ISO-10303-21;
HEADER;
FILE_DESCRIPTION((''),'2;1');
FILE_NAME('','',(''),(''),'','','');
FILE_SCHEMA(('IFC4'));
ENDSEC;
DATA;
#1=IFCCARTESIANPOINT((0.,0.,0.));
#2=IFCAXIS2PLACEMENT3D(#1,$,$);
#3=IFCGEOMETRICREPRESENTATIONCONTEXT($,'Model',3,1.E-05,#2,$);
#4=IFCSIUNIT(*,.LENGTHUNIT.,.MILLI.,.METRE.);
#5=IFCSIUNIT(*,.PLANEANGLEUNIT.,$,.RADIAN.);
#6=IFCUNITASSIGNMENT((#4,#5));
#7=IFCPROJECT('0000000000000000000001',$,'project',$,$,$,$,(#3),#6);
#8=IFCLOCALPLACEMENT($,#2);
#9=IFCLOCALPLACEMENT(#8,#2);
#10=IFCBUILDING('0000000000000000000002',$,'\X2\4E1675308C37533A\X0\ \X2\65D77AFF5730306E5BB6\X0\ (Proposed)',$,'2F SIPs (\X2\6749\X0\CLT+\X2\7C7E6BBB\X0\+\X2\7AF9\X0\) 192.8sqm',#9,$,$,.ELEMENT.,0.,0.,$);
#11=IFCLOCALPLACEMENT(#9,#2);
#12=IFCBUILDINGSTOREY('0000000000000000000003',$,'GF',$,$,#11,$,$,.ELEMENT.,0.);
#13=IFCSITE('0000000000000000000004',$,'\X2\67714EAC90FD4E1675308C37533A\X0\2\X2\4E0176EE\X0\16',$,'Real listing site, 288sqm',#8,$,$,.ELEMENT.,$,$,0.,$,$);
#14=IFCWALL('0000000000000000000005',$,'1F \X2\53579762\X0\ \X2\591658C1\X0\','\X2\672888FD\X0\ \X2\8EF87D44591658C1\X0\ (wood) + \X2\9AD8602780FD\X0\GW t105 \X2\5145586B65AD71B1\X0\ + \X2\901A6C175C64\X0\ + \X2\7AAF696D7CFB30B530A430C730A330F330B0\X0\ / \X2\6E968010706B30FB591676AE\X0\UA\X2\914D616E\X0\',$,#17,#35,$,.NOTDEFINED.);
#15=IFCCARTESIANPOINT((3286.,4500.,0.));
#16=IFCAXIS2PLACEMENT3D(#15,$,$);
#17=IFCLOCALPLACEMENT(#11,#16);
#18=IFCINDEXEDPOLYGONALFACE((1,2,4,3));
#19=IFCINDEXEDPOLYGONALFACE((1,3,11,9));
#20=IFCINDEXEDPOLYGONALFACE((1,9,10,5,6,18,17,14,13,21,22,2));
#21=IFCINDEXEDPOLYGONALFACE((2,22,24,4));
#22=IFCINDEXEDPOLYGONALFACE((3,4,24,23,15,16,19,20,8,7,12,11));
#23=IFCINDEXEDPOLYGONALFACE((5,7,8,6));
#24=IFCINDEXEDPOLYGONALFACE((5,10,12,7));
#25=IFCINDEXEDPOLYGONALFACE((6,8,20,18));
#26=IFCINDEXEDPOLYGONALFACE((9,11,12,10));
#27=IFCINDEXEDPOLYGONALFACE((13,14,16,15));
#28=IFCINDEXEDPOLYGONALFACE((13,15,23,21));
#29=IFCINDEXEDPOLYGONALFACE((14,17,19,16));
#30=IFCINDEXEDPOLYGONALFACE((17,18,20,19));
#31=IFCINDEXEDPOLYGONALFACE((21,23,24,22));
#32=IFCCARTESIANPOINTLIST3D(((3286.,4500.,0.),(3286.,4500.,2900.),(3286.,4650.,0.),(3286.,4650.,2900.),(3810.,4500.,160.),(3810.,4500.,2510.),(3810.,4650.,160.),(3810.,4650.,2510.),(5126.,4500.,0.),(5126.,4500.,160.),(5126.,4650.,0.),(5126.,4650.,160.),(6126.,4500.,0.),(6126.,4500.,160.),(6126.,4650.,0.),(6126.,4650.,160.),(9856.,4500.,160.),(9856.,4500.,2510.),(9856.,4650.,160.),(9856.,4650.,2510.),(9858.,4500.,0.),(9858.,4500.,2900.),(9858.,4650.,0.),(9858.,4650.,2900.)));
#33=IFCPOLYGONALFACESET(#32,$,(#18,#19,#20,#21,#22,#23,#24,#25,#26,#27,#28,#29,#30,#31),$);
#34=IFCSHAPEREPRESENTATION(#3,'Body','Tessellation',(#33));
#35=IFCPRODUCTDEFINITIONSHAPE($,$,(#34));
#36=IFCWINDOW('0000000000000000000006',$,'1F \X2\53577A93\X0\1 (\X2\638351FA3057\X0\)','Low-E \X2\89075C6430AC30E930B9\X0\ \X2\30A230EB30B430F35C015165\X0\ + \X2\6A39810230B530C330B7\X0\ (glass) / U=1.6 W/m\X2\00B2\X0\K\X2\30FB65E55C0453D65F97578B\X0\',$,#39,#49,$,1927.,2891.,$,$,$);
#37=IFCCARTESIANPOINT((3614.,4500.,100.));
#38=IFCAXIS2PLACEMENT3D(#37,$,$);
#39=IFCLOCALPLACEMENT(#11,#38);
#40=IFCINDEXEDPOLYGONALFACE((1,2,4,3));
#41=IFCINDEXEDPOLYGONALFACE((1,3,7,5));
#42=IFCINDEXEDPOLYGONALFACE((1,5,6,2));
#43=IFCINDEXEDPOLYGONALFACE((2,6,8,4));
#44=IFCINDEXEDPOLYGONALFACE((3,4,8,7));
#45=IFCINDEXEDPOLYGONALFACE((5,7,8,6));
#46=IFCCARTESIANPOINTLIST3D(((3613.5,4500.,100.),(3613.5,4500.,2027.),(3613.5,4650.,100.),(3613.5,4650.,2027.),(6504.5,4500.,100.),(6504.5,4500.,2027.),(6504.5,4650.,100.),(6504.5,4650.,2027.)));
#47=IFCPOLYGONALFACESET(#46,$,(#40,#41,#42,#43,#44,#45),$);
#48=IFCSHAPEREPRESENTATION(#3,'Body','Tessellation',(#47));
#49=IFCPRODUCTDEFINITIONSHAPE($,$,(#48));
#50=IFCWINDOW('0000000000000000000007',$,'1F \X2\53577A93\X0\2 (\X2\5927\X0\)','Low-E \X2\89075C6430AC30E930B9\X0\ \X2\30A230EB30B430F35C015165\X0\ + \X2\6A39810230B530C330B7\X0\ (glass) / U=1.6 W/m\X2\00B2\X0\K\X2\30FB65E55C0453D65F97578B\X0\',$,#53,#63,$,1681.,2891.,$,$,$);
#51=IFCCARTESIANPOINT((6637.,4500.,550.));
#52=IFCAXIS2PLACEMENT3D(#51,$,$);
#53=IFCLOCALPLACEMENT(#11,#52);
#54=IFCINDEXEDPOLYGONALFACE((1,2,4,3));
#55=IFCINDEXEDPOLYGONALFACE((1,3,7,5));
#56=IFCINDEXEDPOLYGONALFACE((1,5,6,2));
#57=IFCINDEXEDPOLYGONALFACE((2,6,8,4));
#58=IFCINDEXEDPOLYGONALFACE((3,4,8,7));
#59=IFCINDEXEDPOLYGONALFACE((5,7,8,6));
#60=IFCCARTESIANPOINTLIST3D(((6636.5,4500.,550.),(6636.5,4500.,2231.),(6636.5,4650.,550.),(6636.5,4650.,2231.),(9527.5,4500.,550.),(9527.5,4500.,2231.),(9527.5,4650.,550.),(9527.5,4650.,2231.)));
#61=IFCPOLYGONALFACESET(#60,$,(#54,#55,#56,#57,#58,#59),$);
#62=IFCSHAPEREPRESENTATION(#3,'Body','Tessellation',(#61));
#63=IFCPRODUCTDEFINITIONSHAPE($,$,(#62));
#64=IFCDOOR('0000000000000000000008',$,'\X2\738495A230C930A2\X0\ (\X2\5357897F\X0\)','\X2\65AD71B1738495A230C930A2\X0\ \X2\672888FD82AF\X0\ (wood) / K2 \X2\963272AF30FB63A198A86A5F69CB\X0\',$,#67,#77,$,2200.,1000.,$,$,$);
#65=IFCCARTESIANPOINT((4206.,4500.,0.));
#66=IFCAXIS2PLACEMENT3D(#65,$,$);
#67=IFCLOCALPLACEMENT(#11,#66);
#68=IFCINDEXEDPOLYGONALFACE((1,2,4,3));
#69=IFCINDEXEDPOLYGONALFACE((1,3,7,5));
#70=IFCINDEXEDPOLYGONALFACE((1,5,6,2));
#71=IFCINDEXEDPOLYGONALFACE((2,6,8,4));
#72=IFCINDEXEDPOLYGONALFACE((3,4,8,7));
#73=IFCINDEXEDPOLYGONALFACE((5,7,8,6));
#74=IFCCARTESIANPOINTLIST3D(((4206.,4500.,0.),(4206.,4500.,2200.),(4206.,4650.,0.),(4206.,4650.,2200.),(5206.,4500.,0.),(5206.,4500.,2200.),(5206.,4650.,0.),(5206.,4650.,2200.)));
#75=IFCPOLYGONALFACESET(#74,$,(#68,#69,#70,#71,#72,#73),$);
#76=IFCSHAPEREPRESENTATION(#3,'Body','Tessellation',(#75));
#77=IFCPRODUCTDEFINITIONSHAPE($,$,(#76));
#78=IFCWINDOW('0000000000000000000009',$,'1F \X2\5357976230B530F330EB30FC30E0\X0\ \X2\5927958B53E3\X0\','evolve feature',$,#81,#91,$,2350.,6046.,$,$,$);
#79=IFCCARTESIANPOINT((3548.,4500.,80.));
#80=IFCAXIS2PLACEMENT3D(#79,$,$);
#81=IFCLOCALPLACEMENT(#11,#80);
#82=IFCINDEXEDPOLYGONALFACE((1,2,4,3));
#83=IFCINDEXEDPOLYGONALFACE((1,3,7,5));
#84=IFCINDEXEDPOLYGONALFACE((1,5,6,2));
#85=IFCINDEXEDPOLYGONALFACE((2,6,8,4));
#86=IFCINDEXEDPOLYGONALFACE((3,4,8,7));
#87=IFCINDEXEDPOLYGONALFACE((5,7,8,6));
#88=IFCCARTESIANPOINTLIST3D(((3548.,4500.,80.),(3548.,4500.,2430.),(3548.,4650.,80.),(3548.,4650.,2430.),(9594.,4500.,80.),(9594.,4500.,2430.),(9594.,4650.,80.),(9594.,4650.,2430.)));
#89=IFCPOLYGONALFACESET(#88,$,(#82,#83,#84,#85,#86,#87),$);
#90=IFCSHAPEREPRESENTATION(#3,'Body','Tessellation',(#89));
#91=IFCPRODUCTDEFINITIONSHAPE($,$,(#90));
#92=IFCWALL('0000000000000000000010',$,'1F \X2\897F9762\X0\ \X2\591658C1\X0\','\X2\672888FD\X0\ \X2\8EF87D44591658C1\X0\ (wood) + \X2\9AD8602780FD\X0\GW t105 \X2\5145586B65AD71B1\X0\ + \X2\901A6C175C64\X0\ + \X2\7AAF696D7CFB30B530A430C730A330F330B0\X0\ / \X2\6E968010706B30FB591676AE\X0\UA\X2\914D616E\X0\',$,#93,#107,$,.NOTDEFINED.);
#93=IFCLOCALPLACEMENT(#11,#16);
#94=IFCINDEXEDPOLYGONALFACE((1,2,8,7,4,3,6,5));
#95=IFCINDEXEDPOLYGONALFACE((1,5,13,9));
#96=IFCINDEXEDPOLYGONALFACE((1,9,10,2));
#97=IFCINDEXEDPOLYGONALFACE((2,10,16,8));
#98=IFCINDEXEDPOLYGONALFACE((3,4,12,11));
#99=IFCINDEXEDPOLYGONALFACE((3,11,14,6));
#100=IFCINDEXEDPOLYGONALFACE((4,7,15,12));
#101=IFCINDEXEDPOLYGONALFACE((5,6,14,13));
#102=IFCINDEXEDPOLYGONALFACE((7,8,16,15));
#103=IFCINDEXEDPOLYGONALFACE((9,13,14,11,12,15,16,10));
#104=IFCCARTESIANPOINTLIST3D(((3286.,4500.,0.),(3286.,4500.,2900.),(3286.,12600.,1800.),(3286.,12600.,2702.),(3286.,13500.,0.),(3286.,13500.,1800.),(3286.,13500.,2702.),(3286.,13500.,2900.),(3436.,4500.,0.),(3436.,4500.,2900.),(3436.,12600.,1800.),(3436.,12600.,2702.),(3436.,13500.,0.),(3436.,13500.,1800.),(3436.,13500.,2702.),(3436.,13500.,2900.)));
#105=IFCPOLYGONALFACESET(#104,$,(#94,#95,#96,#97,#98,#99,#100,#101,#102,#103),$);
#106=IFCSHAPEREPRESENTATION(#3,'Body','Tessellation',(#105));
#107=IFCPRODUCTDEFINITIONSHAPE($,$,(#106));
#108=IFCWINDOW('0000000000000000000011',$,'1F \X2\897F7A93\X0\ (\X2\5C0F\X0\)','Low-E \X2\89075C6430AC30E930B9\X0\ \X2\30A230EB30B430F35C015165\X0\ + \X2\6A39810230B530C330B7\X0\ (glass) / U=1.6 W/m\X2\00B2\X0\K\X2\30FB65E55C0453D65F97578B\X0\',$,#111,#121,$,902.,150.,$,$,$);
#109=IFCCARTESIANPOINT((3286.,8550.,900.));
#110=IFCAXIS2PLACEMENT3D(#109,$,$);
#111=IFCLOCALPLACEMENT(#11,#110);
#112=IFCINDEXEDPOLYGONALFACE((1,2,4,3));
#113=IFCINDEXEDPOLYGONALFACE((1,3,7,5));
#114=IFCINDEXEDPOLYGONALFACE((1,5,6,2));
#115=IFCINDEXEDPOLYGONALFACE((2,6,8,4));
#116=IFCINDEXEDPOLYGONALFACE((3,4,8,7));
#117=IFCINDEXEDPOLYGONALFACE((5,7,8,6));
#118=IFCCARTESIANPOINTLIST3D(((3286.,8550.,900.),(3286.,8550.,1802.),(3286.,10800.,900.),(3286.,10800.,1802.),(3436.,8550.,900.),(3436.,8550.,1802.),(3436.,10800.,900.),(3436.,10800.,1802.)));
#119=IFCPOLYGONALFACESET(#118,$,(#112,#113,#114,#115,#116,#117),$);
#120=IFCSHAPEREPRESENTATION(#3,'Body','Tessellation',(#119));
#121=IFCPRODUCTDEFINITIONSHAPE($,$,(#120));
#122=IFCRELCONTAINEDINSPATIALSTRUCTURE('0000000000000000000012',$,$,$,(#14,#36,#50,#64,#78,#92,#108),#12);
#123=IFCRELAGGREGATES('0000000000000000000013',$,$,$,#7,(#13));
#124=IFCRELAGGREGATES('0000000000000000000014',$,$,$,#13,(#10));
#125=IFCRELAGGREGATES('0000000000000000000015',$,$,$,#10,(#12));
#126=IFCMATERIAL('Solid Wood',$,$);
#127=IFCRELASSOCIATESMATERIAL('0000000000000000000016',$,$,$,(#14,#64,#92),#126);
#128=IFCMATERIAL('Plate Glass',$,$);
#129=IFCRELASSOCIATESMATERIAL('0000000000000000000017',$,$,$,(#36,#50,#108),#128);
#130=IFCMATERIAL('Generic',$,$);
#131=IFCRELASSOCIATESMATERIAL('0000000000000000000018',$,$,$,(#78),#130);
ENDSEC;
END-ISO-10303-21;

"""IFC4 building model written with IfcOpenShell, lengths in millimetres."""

from ifc_helpers import new_model, si_unit, frame, frame_2d, origin, place, context, project, spatial, rectangle, extrude, material, element, fill, save


model = new_model("IFC4")

# Units and contexts
model_context = context("Model", 3, precision=1e-05, world=origin())
ifc_project = project(units=[si_unit("LENGTHUNIT", "METRE", prefix="MILLI"), si_unit("PLANEANGLEUNIT", "RADIAN")], contexts=[model_context])

# Site, building, storey
site_placement = place(None, origin())
site = spatial("IfcSite", under=ifc_project, at=site_placement, Name="東京都世田谷区2丁目16", ObjectType="Real listing site, 288sqm", CompositionType="ELEMENT", RefElevation=0.0)
building_placement = place(site_placement, origin())
building = spatial("IfcBuilding", under=site, at=building_placement, Name="世田谷区 旗竿地の家 (Proposed)", ObjectType="2F SIPs (杉CLT+籾殻+竹) 192.8sqm", CompositionType="ELEMENT", ElevationOfRefHeight=0.0, ElevationOfTerrain=0.0)
storey_placement = place(building_placement, origin())
storey = spatial("IfcBuildingStorey", under=building, at=storey_placement, Name="GF", CompositionType="ELEMENT", Elevation=0.0)

# Shared definitions
ifc_material_1 = material(Name="Solid Wood")

# Wall, openings, windows, door
wall_1_placement = place(storey_placement, frame((3286.0, 4500.0, 0.0)))
wall_1 = element("IfcWall", 1, at=wall_1_placement, inside=storey, material=ifc_material_1, Name="1F 南面 外壁", Description="木製 軸組外壁 (wood) + 高性能GW t105 充填断熱 + 通気層 + 窯業系サイディング / 準耐火・外皮UA配慮", PredefinedType="NOTDEFINED", context=model_context, shape_type="SweptSolid", body=[
    extrude(rectangle(XDim=6572.0, YDim=150.0, at=frame_2d((3286.0, 75.0))), frame((3286.0, 4500.0, 0.0)), (0.0, 0.0, 1.0), 2900.0),
])
opening_1_placement = place(storey_placement, frame((3614.0, 4500.0, 100.0)))
opening_1 = element("IfcOpeningElement", 2, at=opening_1_placement, cuts=wall_1, PredefinedType="NOTDEFINED", context=model_context, shape_type="SweptSolid", body=[
    extrude(rectangle(XDim=2891.0, YDim=150.0, at=frame_2d((1445.0, 75.0))), frame((3614.0, 4500.0, 100.0)), (0.0, 0.0, 1.0), 1927.0),
])
opening_2_placement = place(storey_placement, frame((6637.0, 4500.0, 550.0)))
opening_2 = element("IfcOpeningElement", 3, at=opening_2_placement, cuts=wall_1, PredefinedType="NOTDEFINED", context=model_context, shape_type="SweptSolid", body=[
    extrude(rectangle(XDim=2891.0, YDim=150.0, at=frame_2d((1445.0, 75.0))), frame((6637.0, 4500.0, 550.0)), (0.0, 0.0, 1.0), 1681.0),
])
opening_3_placement = place(storey_placement, frame((4206.0, 4500.0, 0.0)))
opening_3 = element("IfcOpeningElement", 4, at=opening_3_placement, cuts=wall_1, PredefinedType="NOTDEFINED", context=model_context, shape_type="SweptSolid", body=[
    extrude(rectangle(XDim=1000.0, YDim=150.0, at=frame_2d((500.0, 75.0))), frame((4206.0, 4500.0, 0.0)), (0.0, 0.0, 1.0), 2200.0),
])
opening_4_placement = place(storey_placement, frame((3548.0, 4500.0, 80.0)))
opening_4 = element("IfcOpeningElement", 5, at=opening_4_placement, cuts=wall_1, PredefinedType="NOTDEFINED", context=model_context, shape_type="SweptSolid", body=[
    extrude(rectangle(XDim=6046.0, YDim=150.0, at=frame_2d((3023.0, 75.0))), frame((3548.0, 4500.0, 80.0)), (0.0, 0.0, 1.0), 2350.0),
])
ifc_material_2 = material(Name="Plate Glass")
window_1_placement = place(storey_placement, frame((3614.0, 4500.0, 100.0)))
window_1 = element("IfcWindow", 6, at=window_1_placement, inside=storey, material=ifc_material_2, Name="1F 南窓1 (掃出し)", Description="Low-E 複層ガラス アルゴン封入 + 樹脂サッシ (glass) / U=1.6 W/m²K・日射取得型", OverallHeight=1927.0, OverallWidth=2891.0, context=model_context, shape_type="SweptSolid", body=[
    extrude(rectangle(XDim=2891.0, YDim=150.0, at=frame_2d((1445.0, 75.0))), frame((3614.0, 4500.0, 100.0)), (0.0, 0.0, 1.0), 1927.0),
])
fill(opening_1, window_1)
window_2_placement = place(storey_placement, frame((6637.0, 4500.0, 550.0)))
window_2 = element("IfcWindow", 7, at=window_2_placement, inside=storey, material=ifc_material_2, Name="1F 南窓2 (大)", Description="Low-E 複層ガラス アルゴン封入 + 樹脂サッシ (glass) / U=1.6 W/m²K・日射取得型", OverallHeight=1681.0, OverallWidth=2891.0, context=model_context, shape_type="SweptSolid", body=[
    extrude(rectangle(XDim=2891.0, YDim=150.0, at=frame_2d((1445.0, 75.0))), frame((6637.0, 4500.0, 550.0)), (0.0, 0.0, 1.0), 1681.0),
])
fill(opening_2, window_2)
door_placement = place(storey_placement, frame((4206.0, 4500.0, 0.0)))
door = element("IfcDoor", 8, at=door_placement, inside=storey, material=ifc_material_1, Name="玄関ドア (南西)", Description="断熱玄関ドア 木製芯 (wood) / K2 防犯・採風機構", OverallHeight=2200.0, OverallWidth=1000.0, context=model_context, shape_type="SweptSolid", body=[
    extrude(rectangle(XDim=1000.0, YDim=150.0, at=frame_2d((500.0, 75.0))), frame((4206.0, 4500.0, 0.0)), (0.0, 0.0, 1.0), 2200.0),
])
fill(opening_3, door)
ifc_material_3 = material(Name="Generic")
window_3_placement = place(storey_placement, frame((3548.0, 4500.0, 80.0)))
window_3 = element("IfcWindow", 9, at=window_3_placement, inside=storey, material=ifc_material_3, Name="1F 南面サンルーム 大開口", Description="evolve feature", OverallHeight=2350.0, OverallWidth=6046.0, context=model_context, shape_type="SweptSolid", body=[
    extrude(rectangle(XDim=6046.0, YDim=150.0, at=frame_2d((3023.0, 75.0))), frame((3548.0, 4500.0, 80.0)), (0.0, 0.0, 1.0), 2350.0),
])
fill(opening_4, window_3)

# Wall, opening, window
wall_2_placement = place(storey_placement, frame((3286.0, 4500.0, 0.0)))
wall_2 = element("IfcWall", 10, at=wall_2_placement, inside=storey, material=ifc_material_1, Name="1F 西面 外壁", Description="木製 軸組外壁 (wood) + 高性能GW t105 充填断熱 + 通気層 + 窯業系サイディング / 準耐火・外皮UA配慮", PredefinedType="NOTDEFINED", context=model_context, shape_type="SweptSolid", body=[
    extrude(rectangle(XDim=150.0, YDim=9000.0, at=frame_2d((75.0, 4500.0))), frame((3286.0, 4500.0, 0.0)), (0.0, 0.0, 1.0), 2900.0),
])
opening_5_placement = place(storey_placement, frame((3286.0, 8550.0, 900.0)))
opening_5 = element("IfcOpeningElement", 11, at=opening_5_placement, cuts=wall_2, PredefinedType="NOTDEFINED", context=model_context, shape_type="SweptSolid", body=[
    extrude(rectangle(XDim=150.0, YDim=2250.0, at=frame_2d((75.0, 1125.0))), frame((3286.0, 8550.0, 900.0)), (0.0, 0.0, 1.0), 902.0),
])
window_4_placement = place(storey_placement, frame((3286.0, 8550.0, 900.0)))
window_4 = element("IfcWindow", 12, at=window_4_placement, inside=storey, material=ifc_material_2, Name="1F 西窓 (小)", Description="Low-E 複層ガラス アルゴン封入 + 樹脂サッシ (glass) / U=1.6 W/m²K・日射取得型", OverallHeight=902.0, OverallWidth=150.0, context=model_context, shape_type="SweptSolid", body=[
    extrude(rectangle(XDim=150.0, YDim=2250.0, at=frame_2d((75.0, 1125.0))), frame((3286.0, 8550.0, 900.0)), (0.0, 0.0, 1.0), 902.0),
])
fill(opening_5, window_4)

save(model, "model.ifc")
